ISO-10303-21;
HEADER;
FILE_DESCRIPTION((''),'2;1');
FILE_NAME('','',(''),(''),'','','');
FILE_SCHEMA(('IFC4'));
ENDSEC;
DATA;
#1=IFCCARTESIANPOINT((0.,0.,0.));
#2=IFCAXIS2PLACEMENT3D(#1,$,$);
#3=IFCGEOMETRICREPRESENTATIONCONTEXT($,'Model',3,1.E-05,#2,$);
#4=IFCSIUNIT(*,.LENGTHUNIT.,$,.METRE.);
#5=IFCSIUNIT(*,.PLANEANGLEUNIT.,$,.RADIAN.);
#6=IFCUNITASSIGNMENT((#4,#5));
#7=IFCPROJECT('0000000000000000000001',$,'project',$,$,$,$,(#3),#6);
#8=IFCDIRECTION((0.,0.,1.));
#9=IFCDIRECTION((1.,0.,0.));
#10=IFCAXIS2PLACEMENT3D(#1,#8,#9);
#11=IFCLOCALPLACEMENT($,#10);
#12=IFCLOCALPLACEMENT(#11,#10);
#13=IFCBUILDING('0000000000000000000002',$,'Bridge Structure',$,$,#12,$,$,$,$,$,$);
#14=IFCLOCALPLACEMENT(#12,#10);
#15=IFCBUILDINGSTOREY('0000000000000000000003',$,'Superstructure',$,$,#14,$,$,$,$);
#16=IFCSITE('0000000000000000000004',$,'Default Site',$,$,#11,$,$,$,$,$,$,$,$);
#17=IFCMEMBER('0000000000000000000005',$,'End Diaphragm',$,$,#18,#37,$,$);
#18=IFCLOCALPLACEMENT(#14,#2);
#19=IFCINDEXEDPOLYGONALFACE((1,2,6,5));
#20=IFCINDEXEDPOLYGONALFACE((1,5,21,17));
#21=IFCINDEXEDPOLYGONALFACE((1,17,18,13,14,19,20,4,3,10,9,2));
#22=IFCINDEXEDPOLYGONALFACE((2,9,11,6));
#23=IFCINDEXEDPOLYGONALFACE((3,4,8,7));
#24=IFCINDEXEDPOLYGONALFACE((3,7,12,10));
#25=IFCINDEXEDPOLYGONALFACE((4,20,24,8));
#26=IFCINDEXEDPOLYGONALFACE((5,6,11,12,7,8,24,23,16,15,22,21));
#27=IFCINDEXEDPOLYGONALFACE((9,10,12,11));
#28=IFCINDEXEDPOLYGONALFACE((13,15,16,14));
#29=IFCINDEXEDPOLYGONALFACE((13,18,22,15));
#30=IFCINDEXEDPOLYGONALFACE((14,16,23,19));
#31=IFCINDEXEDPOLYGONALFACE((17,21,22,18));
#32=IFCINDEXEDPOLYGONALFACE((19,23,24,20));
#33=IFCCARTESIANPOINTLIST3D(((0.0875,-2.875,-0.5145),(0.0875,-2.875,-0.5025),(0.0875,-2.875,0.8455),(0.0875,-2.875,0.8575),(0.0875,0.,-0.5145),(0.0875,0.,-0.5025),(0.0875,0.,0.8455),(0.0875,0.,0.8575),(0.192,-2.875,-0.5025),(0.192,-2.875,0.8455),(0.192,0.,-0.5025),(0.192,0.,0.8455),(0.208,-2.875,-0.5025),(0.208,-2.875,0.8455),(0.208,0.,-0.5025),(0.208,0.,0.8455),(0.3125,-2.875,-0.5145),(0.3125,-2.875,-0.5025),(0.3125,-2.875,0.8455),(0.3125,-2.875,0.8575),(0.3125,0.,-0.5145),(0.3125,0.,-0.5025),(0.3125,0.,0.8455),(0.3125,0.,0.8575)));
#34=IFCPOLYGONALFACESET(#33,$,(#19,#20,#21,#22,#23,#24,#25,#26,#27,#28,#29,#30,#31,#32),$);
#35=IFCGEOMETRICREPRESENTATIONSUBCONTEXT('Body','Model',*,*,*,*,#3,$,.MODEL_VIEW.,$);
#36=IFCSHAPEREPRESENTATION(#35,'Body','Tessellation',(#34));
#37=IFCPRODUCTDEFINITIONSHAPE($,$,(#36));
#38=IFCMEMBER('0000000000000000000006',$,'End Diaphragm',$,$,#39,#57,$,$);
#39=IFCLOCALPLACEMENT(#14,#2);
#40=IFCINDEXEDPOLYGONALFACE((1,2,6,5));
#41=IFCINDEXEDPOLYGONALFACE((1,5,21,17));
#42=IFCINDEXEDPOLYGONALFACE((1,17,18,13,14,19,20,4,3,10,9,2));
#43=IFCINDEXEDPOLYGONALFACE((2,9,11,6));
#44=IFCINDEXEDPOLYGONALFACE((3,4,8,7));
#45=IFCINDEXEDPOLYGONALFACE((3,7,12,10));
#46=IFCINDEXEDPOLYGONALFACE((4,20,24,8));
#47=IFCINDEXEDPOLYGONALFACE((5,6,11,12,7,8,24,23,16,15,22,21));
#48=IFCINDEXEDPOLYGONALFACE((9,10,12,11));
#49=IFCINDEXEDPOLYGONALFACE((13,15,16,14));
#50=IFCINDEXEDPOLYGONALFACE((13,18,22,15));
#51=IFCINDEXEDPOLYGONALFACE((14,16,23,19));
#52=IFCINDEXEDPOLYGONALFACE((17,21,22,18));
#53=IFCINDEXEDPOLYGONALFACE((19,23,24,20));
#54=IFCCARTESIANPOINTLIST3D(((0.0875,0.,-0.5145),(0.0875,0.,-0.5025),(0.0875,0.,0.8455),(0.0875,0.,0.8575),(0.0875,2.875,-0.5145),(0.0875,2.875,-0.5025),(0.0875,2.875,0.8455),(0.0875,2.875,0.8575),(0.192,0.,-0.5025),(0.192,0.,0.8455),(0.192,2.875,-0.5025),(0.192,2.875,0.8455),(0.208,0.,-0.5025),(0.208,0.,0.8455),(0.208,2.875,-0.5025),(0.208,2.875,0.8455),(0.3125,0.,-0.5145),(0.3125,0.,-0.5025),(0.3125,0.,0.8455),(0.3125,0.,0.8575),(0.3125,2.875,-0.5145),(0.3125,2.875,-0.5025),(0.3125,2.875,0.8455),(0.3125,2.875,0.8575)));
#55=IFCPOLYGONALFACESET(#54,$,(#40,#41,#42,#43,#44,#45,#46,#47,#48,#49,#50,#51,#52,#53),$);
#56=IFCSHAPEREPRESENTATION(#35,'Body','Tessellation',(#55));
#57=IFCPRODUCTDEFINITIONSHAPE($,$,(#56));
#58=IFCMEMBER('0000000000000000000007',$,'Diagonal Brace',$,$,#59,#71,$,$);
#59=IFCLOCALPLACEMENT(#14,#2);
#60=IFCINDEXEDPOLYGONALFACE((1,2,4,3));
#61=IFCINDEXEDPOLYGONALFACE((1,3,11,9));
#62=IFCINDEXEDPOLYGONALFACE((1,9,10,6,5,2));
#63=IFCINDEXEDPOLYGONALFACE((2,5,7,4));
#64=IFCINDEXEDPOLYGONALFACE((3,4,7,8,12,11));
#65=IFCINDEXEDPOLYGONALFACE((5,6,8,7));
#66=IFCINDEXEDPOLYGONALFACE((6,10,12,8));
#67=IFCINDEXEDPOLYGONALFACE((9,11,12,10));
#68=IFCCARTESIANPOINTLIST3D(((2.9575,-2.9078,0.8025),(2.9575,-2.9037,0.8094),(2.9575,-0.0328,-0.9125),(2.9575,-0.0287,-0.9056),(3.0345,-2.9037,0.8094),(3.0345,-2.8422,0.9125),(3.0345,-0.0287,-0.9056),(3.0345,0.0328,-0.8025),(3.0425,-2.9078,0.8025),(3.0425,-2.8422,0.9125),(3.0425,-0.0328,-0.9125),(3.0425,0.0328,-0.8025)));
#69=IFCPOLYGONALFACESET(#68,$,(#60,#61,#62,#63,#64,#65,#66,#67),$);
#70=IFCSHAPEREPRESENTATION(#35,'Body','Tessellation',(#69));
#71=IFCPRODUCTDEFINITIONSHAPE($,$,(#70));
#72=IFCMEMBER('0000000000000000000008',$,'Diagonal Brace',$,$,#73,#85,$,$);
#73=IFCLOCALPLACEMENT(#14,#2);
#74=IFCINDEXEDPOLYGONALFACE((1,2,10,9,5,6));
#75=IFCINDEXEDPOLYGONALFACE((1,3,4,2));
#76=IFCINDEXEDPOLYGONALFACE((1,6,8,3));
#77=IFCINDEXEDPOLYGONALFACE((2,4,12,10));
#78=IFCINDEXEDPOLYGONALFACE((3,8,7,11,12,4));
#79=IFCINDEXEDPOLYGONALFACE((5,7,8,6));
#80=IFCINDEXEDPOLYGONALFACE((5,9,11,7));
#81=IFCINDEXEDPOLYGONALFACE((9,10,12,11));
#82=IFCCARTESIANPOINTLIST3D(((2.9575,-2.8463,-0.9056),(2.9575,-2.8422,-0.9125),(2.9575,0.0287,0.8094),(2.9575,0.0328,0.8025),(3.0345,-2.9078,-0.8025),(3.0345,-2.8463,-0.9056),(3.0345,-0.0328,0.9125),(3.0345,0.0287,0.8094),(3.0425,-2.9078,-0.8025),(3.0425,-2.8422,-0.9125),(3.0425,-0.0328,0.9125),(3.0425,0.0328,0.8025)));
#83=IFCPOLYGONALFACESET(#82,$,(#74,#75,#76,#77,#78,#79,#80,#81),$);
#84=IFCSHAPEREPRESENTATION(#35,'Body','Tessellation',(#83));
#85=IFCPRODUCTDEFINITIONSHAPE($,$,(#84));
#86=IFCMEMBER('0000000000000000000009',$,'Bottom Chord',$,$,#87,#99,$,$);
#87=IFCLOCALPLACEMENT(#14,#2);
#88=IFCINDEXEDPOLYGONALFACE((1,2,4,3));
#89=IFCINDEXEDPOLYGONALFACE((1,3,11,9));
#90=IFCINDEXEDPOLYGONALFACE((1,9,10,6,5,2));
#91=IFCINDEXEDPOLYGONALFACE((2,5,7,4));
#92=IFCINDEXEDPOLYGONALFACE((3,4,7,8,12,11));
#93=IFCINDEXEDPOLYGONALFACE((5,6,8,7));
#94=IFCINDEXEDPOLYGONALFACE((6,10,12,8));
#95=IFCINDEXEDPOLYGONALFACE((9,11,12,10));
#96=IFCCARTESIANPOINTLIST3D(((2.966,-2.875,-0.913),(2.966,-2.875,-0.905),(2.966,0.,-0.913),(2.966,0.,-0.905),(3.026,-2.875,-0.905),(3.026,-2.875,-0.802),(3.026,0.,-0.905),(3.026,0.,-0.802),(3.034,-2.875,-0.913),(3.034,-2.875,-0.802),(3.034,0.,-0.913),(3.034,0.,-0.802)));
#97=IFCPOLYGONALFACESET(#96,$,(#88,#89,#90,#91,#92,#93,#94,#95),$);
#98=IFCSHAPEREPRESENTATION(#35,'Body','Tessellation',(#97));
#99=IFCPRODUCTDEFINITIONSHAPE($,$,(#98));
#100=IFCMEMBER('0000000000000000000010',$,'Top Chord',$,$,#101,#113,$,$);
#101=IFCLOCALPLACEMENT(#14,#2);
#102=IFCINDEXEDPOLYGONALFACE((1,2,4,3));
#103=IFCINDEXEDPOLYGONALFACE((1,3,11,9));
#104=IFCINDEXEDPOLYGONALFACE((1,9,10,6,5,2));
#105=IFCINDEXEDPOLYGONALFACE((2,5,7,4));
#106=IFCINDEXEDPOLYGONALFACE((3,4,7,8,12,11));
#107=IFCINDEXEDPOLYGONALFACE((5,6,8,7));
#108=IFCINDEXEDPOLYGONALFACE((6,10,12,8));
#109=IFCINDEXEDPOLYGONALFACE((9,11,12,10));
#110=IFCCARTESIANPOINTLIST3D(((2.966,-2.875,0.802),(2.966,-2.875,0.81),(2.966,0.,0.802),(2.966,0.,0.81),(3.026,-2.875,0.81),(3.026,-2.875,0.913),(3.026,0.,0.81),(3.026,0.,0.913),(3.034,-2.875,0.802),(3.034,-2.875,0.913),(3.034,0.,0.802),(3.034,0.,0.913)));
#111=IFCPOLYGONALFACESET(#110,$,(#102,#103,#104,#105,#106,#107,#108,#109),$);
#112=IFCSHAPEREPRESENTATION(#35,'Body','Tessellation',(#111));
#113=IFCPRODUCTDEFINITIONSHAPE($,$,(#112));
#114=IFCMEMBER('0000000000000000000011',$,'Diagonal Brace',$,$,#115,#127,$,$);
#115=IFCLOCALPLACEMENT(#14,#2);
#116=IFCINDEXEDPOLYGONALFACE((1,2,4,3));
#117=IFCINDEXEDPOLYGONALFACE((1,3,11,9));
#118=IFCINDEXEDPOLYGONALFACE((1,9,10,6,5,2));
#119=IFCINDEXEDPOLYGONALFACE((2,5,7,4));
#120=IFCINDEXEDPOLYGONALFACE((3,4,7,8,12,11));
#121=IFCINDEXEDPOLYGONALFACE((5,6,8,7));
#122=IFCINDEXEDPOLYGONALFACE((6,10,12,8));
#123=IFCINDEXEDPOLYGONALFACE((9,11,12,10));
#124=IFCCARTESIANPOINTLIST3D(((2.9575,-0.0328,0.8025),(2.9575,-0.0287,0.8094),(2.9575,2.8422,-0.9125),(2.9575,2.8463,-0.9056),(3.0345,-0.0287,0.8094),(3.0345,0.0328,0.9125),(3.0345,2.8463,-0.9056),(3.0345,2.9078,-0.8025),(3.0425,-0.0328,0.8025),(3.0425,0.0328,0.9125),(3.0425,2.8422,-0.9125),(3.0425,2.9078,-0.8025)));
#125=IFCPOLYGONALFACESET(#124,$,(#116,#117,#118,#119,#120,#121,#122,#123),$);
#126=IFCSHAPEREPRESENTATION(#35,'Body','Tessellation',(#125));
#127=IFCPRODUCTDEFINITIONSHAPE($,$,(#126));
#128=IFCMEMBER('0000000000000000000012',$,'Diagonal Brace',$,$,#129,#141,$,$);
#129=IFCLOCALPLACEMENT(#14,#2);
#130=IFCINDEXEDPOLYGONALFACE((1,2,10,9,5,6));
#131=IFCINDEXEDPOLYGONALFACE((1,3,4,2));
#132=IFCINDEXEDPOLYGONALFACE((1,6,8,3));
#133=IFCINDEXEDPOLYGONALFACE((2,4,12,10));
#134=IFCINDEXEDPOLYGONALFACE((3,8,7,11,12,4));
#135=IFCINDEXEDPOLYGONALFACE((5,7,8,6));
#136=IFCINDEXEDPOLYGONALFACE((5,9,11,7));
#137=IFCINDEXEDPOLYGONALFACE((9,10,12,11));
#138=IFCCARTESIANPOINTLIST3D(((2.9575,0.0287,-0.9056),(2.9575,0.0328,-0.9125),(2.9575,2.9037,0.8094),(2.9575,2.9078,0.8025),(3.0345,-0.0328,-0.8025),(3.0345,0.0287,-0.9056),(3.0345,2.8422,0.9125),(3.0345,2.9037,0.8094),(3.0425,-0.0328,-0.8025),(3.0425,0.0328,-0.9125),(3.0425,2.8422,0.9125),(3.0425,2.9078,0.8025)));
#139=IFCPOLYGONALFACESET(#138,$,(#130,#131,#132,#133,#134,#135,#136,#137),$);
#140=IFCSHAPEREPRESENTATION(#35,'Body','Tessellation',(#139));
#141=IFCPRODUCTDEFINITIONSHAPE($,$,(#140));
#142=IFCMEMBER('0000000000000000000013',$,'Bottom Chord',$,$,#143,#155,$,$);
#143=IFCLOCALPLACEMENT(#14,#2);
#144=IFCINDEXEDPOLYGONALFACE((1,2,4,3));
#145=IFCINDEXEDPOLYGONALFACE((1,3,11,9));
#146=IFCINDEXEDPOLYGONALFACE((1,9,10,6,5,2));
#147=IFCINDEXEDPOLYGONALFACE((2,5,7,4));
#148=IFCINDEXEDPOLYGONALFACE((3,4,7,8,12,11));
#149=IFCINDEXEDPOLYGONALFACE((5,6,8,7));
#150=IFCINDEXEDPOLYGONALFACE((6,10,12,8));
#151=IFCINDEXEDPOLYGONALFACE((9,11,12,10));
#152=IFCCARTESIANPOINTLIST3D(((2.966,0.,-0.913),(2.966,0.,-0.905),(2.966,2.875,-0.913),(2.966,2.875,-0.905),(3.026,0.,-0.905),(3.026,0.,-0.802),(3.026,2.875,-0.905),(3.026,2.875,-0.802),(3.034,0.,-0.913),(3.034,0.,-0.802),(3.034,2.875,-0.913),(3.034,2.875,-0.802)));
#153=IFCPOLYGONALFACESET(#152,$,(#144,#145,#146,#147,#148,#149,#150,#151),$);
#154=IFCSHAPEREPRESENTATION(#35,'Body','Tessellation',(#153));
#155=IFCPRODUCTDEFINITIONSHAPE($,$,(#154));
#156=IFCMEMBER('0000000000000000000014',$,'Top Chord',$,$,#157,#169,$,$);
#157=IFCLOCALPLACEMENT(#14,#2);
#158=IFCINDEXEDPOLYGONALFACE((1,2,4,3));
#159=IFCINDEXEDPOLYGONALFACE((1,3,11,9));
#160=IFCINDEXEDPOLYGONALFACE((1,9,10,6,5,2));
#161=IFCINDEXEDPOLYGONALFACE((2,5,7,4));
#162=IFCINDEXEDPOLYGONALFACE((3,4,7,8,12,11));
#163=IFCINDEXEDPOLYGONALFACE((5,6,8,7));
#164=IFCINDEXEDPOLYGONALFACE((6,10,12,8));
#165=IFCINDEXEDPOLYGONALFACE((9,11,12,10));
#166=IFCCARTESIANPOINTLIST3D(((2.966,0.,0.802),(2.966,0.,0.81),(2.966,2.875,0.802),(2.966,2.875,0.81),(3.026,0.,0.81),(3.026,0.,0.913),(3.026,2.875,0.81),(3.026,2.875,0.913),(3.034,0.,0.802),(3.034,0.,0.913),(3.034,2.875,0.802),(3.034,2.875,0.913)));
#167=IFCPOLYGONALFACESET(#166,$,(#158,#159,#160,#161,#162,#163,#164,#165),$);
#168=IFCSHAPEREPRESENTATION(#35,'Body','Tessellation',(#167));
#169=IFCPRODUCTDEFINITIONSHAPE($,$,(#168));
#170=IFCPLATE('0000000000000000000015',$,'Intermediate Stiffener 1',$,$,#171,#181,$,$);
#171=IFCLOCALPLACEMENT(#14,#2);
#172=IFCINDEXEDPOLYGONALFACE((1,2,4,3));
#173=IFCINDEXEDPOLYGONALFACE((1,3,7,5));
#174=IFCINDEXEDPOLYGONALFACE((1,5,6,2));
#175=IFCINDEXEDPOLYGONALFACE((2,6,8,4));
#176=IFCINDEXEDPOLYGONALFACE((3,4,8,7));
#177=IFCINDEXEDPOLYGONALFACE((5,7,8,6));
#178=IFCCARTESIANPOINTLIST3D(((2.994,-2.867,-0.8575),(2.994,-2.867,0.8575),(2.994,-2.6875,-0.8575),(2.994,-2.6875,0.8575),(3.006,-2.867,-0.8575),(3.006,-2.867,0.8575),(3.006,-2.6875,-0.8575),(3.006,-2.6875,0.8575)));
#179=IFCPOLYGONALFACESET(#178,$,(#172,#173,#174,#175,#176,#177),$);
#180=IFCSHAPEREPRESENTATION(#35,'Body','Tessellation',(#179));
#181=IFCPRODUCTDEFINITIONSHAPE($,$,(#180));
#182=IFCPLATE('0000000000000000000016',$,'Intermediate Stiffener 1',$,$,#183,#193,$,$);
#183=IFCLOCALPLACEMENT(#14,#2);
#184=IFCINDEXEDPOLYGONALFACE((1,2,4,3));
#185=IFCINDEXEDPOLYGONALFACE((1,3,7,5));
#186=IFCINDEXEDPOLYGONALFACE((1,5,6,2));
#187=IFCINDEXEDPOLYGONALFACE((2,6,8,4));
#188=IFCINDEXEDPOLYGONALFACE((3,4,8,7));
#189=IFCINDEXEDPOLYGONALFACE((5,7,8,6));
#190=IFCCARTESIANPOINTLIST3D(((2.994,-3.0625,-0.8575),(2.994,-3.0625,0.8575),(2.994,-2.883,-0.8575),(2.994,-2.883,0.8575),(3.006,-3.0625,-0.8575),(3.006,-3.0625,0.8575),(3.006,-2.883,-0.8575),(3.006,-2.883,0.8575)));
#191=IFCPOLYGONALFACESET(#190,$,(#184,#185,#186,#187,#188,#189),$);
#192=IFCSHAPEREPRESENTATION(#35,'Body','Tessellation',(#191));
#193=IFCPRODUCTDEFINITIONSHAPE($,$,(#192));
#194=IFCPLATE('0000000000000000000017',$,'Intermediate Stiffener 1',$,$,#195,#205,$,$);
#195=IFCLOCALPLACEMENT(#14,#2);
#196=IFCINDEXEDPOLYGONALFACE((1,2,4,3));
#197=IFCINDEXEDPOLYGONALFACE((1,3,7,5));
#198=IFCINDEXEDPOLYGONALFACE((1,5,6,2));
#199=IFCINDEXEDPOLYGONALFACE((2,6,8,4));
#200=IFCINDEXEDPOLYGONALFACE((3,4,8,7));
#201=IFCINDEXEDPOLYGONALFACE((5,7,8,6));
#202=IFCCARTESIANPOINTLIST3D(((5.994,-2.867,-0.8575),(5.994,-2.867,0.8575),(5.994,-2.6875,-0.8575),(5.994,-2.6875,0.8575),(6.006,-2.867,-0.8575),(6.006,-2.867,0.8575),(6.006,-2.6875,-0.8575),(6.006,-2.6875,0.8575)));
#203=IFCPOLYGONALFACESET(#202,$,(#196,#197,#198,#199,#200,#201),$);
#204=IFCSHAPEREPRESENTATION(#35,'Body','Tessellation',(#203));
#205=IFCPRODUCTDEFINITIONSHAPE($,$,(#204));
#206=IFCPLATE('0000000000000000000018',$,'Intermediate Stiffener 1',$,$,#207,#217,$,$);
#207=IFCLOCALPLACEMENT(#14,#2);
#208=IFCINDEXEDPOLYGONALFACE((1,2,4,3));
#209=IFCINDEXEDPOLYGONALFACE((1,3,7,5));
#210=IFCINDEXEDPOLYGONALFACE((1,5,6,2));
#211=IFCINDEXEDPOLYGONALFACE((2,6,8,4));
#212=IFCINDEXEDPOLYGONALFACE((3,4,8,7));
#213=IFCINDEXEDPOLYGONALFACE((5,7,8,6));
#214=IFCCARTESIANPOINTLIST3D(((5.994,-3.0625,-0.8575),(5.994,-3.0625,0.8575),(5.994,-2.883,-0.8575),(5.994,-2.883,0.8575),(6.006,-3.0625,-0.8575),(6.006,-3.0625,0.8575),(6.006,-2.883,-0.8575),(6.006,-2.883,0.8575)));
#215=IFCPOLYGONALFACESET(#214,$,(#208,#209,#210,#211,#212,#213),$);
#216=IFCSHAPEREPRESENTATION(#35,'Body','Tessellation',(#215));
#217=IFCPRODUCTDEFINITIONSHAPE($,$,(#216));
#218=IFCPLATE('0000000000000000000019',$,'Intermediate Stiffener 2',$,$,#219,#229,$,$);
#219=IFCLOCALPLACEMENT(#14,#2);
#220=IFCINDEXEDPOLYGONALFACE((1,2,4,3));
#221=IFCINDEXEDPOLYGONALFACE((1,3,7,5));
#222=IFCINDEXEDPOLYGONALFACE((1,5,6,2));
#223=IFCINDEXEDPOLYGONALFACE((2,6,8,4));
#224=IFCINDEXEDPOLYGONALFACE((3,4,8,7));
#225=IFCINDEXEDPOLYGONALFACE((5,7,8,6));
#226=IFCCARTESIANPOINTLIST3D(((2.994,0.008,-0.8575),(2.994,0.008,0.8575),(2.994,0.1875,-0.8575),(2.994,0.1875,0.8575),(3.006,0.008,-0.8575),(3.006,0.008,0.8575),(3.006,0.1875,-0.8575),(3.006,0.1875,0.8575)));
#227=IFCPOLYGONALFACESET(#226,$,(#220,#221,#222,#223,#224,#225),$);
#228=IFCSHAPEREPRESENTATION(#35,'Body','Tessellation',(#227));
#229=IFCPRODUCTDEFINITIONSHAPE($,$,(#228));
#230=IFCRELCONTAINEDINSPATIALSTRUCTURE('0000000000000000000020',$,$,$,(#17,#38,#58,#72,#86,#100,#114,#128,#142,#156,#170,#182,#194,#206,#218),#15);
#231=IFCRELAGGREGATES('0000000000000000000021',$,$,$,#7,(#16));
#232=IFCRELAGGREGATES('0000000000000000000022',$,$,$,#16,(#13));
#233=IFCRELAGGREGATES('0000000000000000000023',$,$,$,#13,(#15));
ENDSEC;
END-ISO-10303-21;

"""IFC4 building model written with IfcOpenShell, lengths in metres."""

from ifc_helpers import new_model, si_unit, frame, origin, origin_with_axes, origin_2d_with_axis, place, context, subcontext, project, spatial, rectangle, i_section, l_section, extrude, element, save


model = new_model("IFC4")

# Units and contexts
model_context = context("Model", 3, precision=1e-05, world=origin())
body_context = subcontext(model_context, "Body", "Model", "MODEL_VIEW")
ifc_project = project(units=[si_unit("LENGTHUNIT", "METRE"), si_unit("PLANEANGLEUNIT", "RADIAN")], contexts=[model_context])

# Site, building, storey
site_placement = place(None, origin_with_axes())
site = spatial("IfcSite", under=ifc_project, at=site_placement, Name="Default Site")
building_placement = place(site_placement, origin_with_axes())
building = spatial("IfcBuilding", under=site, at=building_placement, Name="Bridge Structure")
storey_placement = place(building_placement, origin_with_axes())
storey = spatial("IfcBuildingStorey", under=building, at=storey_placement, Name="Superstructure")

# Members
for number, where, z_axis, x_axis, name in (
    (1, (0.2, -2.875, 0.1715), (0.0, 1.0, 0.0), (-1.0, 0.0, 0.0), "End Diaphragm"),
    (2, (0.2, 0.0, 0.1715), (0.0, 1.0, 0.0), (-1.0, 0.0, 0.0), "End Diaphragm"),
):
    element("IfcMember", number, at=place(storey_placement, frame(where, z_axis=z_axis, x_axis=x_axis)), inside=storey, Name=name, context=body_context, shape_type="SweptSolid", body=[
        extrude(i_section(OverallWidth=0.225, OverallDepth=1.372, WebThickness=0.016, FlangeThickness=0.012, at=origin_2d_with_axis()), origin_with_axes(), (0.0, 0.0, 1.0), 2.875),
    ])
for number, where, z_axis, x_axis, name in (
    (3, (3.0, -2.875, 0.8575), (0.0, 0.858808, -0.512298), (-1.0, 0.0, 0.0), "Diagonal Brace"),
    (4, (3.0, -2.875, -0.8575), (0.0, 0.858808, 0.512298), (-1.0, 0.0, 0.0), "Diagonal Brace"),
):
    element("IfcMember", number, at=place(storey_placement, frame(where, z_axis=z_axis, x_axis=x_axis)), inside=storey, Name=name, context=body_context, shape_type="SweptSolid", body=[
        extrude(l_section(Depth=0.128, Width=0.085, Thickness=0.008, at=origin_2d_with_axis()), origin_with_axes(), (0.0, 0.0, 1.0), 3.3477),
    ])
for number, where, z_axis, x_axis, name in (
    (5, (3.0, -2.875, -0.8575), (0.0, 1.0, 0.0), (-1.0, 0.0, 0.0), "Bottom Chord"),
    (6, (3.0, -2.875, 0.8575), (0.0, 1.0, 0.0), (-1.0, 0.0, 0.0), "Top Chord"),
):
    element("IfcMember", number, at=place(storey_placement, frame(where, z_axis=z_axis, x_axis=x_axis)), inside=storey, Name=name, context=body_context, shape_type="SweptSolid", body=[
        extrude(l_section(Depth=0.111, Width=0.068, Thickness=0.008, at=origin_2d_with_axis()), origin_with_axes(), (0.0, 0.0, 1.0), 2.875),
    ])
for number, where, z_axis, x_axis, name in (
    (7, (3.0, 0.0, 0.8575), (0.0, 0.858808, -0.512298), (-1.0, 0.0, 0.0), "Diagonal Brace"),
    (8, (3.0, 0.0, -0.8575), (0.0, 0.858808, 0.512298), (-1.0, 0.0, 0.0), "Diagonal Brace"),
):
    element("IfcMember", number, at=place(storey_placement, frame(where, z_axis=z_axis, x_axis=x_axis)), inside=storey, Name=name, context=body_context, shape_type="SweptSolid", body=[
        extrude(l_section(Depth=0.128, Width=0.085, Thickness=0.008, at=origin_2d_with_axis()), origin_with_axes(), (0.0, 0.0, 1.0), 3.3477),
    ])
for number, where, z_axis, x_axis, name in (
    (9, (3.0, 0.0, -0.8575), (0.0, 1.0, 0.0), (-1.0, 0.0, 0.0), "Bottom Chord"),
    (10, (3.0, 0.0, 0.8575), (0.0, 1.0, 0.0), (-1.0, 0.0, 0.0), "Top Chord"),
):
    element("IfcMember", number, at=place(storey_placement, frame(where, z_axis=z_axis, x_axis=x_axis)), inside=storey, Name=name, context=body_context, shape_type="SweptSolid", body=[
        extrude(l_section(Depth=0.111, Width=0.068, Thickness=0.008, at=origin_2d_with_axis()), origin_with_axes(), (0.0, 0.0, 1.0), 2.875),
    ])

# Plates
for number, where, z_axis, x_axis, name in (
    (11, (3.0, -2.7772, -0.8575), (0.0, 0.0, 1.0), (1.0, 0.0, 0.0), "Intermediate Stiffener 1"),
    (12, (3.0, -2.9728, -0.8575), (0.0, 0.0, 1.0), (1.0, 0.0, 0.0), "Intermediate Stiffener 1"),
    (13, (6.0, -2.7772, -0.8575), (0.0, 0.0, 1.0), (1.0, 0.0, 0.0), "Intermediate Stiffener 1"),
    (14, (6.0, -2.9728, -0.8575), (0.0, 0.0, 1.0), (1.0, 0.0, 0.0), "Intermediate Stiffener 1"),
    (15, (3.0, 0.0978, -0.8575), (0.0, 0.0, 1.0), (1.0, 0.0, 0.0), "Intermediate Stiffener 2"),
):
    element("IfcPlate", number, at=place(storey_placement, frame(where, z_axis=z_axis, x_axis=x_axis)), inside=storey, Name=name, context=body_context, shape_type="SweptSolid", body=[
        extrude(rectangle(XDim=0.012, YDim=0.1795, at=origin_2d_with_axis()), origin_with_axes(), (0.0, 0.0, 1.0), 1.715),
    ])

save(model, "model.ifc")
